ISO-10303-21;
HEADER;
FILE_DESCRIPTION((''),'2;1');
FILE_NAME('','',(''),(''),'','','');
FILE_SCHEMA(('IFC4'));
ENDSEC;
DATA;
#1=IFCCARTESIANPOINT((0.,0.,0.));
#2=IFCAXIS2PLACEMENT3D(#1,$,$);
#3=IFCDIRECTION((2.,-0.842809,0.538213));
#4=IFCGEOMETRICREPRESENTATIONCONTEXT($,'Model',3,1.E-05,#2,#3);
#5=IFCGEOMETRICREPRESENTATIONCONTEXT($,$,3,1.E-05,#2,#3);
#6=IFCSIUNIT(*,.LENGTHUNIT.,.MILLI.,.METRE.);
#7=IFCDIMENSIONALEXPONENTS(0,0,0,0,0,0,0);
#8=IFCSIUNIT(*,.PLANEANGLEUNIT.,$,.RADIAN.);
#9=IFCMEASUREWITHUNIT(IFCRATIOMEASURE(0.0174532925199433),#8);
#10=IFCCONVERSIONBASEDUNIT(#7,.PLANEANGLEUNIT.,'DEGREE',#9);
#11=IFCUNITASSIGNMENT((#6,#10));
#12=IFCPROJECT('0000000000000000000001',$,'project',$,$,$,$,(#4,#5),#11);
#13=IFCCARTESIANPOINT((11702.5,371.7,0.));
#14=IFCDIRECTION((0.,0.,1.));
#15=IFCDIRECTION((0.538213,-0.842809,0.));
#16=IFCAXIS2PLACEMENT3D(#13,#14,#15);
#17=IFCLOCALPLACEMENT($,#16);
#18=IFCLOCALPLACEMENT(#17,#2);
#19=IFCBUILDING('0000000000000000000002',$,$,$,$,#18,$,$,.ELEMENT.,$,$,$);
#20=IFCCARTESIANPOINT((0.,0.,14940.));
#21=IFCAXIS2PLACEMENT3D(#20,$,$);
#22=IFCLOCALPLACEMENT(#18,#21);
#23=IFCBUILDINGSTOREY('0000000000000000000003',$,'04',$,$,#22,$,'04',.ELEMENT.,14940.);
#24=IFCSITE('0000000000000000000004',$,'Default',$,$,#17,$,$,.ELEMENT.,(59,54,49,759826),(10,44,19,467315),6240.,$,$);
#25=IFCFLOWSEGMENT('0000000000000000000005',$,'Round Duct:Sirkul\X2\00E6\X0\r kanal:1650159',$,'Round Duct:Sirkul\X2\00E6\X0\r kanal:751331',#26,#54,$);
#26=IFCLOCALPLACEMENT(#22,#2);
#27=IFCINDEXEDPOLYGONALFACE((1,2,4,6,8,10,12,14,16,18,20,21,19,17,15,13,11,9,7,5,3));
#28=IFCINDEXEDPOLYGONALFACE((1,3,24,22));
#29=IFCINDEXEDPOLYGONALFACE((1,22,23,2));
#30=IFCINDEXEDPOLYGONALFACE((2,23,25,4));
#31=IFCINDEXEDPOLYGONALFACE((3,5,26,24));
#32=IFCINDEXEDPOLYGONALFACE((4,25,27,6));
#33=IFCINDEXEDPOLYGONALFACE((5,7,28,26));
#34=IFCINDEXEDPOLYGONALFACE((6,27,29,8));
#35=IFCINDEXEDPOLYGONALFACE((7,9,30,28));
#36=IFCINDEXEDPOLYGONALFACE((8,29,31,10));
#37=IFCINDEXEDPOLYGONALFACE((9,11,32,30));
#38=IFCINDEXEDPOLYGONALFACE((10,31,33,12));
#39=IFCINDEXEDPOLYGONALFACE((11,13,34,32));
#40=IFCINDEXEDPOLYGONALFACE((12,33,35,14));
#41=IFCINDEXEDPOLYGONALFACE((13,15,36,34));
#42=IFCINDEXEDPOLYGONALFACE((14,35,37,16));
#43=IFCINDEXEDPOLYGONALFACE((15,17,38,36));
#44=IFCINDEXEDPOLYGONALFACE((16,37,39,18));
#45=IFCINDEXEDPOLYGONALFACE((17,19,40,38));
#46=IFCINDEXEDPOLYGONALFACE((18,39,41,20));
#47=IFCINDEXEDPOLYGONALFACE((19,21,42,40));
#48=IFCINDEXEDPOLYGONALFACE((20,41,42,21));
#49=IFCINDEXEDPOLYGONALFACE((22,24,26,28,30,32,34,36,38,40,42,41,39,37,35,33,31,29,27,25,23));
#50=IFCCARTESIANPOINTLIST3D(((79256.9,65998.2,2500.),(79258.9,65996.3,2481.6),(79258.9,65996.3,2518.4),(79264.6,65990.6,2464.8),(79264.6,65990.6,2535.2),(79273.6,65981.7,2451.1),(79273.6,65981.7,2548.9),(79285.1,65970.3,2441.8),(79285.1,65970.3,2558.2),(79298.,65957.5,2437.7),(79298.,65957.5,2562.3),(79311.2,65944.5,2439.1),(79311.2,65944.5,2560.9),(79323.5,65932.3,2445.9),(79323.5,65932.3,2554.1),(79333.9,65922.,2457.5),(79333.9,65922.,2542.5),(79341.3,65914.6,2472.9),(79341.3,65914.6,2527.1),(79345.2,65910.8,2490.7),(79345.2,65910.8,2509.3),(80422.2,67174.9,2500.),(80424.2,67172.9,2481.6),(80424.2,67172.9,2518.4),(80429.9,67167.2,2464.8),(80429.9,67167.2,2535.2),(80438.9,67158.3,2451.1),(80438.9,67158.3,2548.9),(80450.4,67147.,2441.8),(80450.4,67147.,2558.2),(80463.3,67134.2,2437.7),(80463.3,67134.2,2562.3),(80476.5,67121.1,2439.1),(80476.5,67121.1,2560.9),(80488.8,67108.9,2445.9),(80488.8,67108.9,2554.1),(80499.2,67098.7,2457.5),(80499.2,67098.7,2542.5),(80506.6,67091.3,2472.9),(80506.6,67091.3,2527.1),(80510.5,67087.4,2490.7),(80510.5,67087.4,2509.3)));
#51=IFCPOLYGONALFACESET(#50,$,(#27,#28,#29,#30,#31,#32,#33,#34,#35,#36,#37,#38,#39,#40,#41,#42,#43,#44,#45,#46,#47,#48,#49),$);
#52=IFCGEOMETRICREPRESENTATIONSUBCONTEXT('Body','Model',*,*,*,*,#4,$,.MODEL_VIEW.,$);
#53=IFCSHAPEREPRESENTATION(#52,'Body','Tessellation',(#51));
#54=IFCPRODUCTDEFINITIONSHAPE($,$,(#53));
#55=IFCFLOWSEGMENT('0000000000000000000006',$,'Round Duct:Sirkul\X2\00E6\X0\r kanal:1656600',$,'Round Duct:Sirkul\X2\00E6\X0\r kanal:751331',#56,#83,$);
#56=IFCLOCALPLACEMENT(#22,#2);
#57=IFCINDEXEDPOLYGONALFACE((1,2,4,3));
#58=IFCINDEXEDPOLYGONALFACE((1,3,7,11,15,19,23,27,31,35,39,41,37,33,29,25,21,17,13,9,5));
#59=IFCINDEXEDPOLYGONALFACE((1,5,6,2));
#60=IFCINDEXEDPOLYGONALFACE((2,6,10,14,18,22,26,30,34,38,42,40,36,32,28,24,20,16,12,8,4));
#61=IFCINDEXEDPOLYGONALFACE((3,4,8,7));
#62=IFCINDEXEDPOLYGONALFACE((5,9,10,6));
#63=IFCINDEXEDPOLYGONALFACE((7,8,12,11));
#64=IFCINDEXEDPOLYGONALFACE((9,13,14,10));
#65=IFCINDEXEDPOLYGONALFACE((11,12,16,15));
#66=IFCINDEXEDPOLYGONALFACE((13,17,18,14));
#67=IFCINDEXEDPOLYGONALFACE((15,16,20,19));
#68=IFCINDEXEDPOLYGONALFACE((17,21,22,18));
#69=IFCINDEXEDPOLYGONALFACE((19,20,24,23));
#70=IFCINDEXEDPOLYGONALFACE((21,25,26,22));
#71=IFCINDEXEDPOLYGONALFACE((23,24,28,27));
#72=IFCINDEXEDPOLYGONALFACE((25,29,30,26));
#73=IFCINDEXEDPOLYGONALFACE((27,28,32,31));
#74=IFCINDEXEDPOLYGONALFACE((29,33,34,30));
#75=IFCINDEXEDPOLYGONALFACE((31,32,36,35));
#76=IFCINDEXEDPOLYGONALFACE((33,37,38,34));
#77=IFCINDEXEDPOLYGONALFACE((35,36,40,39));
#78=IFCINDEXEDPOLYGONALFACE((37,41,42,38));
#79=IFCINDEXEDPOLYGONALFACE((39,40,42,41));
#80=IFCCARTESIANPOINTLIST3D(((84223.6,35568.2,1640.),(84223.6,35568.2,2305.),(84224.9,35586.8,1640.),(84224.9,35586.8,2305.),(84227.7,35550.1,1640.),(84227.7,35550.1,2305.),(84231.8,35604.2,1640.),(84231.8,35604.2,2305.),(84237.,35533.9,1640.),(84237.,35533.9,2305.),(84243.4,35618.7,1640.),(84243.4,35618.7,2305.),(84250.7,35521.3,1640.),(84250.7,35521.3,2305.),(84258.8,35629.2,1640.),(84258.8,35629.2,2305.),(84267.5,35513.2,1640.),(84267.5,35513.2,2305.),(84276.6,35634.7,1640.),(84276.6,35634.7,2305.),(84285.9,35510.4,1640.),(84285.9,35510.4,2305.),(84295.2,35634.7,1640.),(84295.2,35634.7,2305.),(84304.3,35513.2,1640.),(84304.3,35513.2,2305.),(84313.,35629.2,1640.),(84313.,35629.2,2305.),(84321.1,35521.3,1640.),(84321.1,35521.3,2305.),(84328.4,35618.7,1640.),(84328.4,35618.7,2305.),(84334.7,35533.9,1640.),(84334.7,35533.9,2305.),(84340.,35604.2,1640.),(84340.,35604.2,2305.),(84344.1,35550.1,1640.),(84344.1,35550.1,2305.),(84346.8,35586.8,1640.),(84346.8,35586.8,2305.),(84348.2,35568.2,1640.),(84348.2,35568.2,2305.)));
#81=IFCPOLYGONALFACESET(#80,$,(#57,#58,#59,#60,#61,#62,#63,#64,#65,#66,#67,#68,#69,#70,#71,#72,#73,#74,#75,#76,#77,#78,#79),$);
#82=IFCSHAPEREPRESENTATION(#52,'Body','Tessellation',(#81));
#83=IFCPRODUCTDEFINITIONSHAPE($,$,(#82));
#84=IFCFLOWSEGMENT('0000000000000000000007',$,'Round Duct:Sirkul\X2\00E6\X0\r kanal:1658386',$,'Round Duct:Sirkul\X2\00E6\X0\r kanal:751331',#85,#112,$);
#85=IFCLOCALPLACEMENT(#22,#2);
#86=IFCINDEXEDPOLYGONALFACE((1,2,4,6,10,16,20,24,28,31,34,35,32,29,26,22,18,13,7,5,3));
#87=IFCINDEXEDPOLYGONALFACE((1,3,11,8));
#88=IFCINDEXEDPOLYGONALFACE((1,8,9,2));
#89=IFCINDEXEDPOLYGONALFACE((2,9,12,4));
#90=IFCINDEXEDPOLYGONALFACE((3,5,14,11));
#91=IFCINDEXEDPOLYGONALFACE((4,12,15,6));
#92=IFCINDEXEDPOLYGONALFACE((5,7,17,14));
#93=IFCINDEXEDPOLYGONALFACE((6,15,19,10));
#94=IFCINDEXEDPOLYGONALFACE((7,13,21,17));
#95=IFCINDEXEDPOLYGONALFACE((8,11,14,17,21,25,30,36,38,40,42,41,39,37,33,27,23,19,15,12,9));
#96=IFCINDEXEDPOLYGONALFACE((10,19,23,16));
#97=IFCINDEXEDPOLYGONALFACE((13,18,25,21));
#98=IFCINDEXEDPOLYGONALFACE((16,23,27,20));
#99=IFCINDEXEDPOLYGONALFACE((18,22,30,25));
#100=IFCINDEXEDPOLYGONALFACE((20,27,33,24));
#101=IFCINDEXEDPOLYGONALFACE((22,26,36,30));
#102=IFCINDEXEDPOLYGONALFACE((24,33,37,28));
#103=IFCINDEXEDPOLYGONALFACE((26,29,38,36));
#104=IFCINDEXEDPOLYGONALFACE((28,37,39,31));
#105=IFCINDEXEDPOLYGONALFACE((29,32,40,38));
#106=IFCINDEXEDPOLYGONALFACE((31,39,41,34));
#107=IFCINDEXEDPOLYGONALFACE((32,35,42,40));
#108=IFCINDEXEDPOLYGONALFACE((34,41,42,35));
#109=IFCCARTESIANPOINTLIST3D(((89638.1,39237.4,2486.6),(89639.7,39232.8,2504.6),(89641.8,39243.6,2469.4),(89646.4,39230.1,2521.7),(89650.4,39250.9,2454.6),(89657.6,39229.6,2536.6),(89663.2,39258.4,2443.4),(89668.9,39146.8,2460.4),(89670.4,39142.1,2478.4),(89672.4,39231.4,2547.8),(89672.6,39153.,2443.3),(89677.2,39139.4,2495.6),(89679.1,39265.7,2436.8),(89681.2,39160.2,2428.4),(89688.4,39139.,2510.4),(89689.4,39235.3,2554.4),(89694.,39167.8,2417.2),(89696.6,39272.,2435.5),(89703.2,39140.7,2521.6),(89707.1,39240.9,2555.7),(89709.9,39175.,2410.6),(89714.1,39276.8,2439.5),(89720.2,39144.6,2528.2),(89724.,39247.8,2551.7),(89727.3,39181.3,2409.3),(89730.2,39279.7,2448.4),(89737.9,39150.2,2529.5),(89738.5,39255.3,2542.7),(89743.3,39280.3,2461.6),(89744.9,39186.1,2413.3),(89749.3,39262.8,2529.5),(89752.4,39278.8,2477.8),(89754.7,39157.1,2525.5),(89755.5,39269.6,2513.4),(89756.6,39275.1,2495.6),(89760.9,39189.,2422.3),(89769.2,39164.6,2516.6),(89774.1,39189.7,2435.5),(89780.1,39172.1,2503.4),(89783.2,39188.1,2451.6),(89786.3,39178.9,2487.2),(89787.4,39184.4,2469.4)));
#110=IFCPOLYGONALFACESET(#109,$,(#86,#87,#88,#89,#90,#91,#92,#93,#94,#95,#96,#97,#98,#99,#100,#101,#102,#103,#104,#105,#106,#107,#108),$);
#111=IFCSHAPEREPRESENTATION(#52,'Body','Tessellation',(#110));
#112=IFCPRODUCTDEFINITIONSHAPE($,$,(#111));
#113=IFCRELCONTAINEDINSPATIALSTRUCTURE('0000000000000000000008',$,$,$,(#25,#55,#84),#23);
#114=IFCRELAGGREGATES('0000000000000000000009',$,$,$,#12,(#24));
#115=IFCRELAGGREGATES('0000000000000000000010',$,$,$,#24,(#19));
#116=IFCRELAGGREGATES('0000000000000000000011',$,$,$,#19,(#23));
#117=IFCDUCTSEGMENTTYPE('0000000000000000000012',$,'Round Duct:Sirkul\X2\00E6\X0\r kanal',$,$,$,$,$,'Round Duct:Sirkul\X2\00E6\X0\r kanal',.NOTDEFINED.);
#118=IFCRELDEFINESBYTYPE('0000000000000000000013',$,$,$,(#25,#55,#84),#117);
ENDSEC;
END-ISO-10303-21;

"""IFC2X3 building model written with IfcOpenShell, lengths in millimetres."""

from ifc_helpers import new_model, entity, si_unit, converted_unit, direction, frame, frame_2d, origin, origin_2d_with_axis, place, context, subcontext, project, spatial, circle, extrude, type_object, element, save


model = new_model("IFC2X3")

# Units and contexts
model_context = context("Model", 3, precision=1e-05, world=origin(), true_north=direction((2.0, -0.842809, 0.538213)))
context_of_model = context(None, 3, precision=1e-05, world=origin(), true_north=direction((2.0, -0.842809, 0.538213)))
body_context = subcontext(model_context, "Body", "Model", "MODEL_VIEW")
ifc_project = project(units=[si_unit("LENGTHUNIT", "METRE", prefix="MILLI"), converted_unit("PLANEANGLEUNIT", "DEGREE", entity("IfcRatioMeasure", 0.0174532925199433), si_unit("PLANEANGLEUNIT", "RADIAN"), dimensions=[0, 0, 0, 0, 0, 0, 0])], contexts=[model_context, context_of_model])

# Site, building, storey
site_placement = place(None, frame((11702.5, 371.7, 0.0), z_axis=(0.0, 0.0, 1.0), x_axis=(0.538213, -0.842809, 0.0)))
site = spatial("IfcSite", under=ifc_project, at=site_placement, Name="Default", CompositionType="ELEMENT", RefLatitude=(59, 54, 49, 759826), RefLongitude=(10, 44, 19, 467315), RefElevation=6240.0)
building_placement = place(site_placement, origin())
building = spatial("IfcBuilding", under=site, at=building_placement, CompositionType="ELEMENT")
storey_placement = place(building_placement, frame((0.0, 0.0, 14940.0)))
storey = spatial("IfcBuildingStorey", under=building, at=storey_placement, Name="04", LongName="04", CompositionType="ELEMENT", Elevation=14940.0)

# Flow segments
duct_segment_type_1 = type_object("IfcDuctSegmentType", Name="Round Duct:Sirkulær kanal", ElementType="Round Duct:Sirkulær kanal", PredefinedType="NOTDEFINED")
flow_segment_1_placement = place(storey_placement, origin())
element("IfcFlowSegment", 1, at=flow_segment_1_placement, inside=storey, type_object=duct_segment_type_1, Name="Round Duct:Sirkulær kanal:1650159", ObjectType="Round Duct:Sirkulær kanal:751331", context=body_context, shape_type="SweptSolid", body=[
    extrude(circle(Radius=62.5, at=origin_2d_with_axis()), frame((79301.3, 65954.3, 2500.0), z_axis=(0.703669, 0.710528, 0.0), x_axis=(-0.710528, 0.703669, 0.0)), (0.0, 0.0, 1.0), 1656.0),
])
flow_segment_2_placement = place(storey_placement, origin())
element("IfcFlowSegment", 2, at=flow_segment_2_placement, inside=storey, type_object=duct_segment_type_1, Name="Round Duct:Sirkulær kanal:1656600", ObjectType="Round Duct:Sirkulær kanal:751331", context=body_context, shape_type="SweptSolid", body=[
    extrude(circle(Radius=62.5, at=origin_2d_with_axis()), frame((84285.9, 35572.9, 1640.0), z_axis=(0.0, 0.0, 1.0), x_axis=(0.0, -1.0, 0.0)), (0.0, 0.0, 1.0), 665.0),
])
flow_segment_3_placement = place(storey_placement, origin())
element("IfcFlowSegment", 3, at=flow_segment_3_placement, inside=storey, type_object=duct_segment_type_1, Name="Round Duct:Sirkulær kanal:1658386", ObjectType="Round Duct:Sirkulær kanal:751331", context=body_context, shape_type="SweptSolid", body=[
    extrude(circle(Radius=62.5, at=frame_2d((0.0, 0.0), x_axis=(1.0, 0.0))), frame((89697.4, 39255.0, 2495.6), z_axis=(0.309916, -0.913508, -0.263544), x_axis=(0.946986, 0.321274, 0.0)), (0.0, 0.0, 1.0), 99.3),
])

save(model, "model.ifc")
